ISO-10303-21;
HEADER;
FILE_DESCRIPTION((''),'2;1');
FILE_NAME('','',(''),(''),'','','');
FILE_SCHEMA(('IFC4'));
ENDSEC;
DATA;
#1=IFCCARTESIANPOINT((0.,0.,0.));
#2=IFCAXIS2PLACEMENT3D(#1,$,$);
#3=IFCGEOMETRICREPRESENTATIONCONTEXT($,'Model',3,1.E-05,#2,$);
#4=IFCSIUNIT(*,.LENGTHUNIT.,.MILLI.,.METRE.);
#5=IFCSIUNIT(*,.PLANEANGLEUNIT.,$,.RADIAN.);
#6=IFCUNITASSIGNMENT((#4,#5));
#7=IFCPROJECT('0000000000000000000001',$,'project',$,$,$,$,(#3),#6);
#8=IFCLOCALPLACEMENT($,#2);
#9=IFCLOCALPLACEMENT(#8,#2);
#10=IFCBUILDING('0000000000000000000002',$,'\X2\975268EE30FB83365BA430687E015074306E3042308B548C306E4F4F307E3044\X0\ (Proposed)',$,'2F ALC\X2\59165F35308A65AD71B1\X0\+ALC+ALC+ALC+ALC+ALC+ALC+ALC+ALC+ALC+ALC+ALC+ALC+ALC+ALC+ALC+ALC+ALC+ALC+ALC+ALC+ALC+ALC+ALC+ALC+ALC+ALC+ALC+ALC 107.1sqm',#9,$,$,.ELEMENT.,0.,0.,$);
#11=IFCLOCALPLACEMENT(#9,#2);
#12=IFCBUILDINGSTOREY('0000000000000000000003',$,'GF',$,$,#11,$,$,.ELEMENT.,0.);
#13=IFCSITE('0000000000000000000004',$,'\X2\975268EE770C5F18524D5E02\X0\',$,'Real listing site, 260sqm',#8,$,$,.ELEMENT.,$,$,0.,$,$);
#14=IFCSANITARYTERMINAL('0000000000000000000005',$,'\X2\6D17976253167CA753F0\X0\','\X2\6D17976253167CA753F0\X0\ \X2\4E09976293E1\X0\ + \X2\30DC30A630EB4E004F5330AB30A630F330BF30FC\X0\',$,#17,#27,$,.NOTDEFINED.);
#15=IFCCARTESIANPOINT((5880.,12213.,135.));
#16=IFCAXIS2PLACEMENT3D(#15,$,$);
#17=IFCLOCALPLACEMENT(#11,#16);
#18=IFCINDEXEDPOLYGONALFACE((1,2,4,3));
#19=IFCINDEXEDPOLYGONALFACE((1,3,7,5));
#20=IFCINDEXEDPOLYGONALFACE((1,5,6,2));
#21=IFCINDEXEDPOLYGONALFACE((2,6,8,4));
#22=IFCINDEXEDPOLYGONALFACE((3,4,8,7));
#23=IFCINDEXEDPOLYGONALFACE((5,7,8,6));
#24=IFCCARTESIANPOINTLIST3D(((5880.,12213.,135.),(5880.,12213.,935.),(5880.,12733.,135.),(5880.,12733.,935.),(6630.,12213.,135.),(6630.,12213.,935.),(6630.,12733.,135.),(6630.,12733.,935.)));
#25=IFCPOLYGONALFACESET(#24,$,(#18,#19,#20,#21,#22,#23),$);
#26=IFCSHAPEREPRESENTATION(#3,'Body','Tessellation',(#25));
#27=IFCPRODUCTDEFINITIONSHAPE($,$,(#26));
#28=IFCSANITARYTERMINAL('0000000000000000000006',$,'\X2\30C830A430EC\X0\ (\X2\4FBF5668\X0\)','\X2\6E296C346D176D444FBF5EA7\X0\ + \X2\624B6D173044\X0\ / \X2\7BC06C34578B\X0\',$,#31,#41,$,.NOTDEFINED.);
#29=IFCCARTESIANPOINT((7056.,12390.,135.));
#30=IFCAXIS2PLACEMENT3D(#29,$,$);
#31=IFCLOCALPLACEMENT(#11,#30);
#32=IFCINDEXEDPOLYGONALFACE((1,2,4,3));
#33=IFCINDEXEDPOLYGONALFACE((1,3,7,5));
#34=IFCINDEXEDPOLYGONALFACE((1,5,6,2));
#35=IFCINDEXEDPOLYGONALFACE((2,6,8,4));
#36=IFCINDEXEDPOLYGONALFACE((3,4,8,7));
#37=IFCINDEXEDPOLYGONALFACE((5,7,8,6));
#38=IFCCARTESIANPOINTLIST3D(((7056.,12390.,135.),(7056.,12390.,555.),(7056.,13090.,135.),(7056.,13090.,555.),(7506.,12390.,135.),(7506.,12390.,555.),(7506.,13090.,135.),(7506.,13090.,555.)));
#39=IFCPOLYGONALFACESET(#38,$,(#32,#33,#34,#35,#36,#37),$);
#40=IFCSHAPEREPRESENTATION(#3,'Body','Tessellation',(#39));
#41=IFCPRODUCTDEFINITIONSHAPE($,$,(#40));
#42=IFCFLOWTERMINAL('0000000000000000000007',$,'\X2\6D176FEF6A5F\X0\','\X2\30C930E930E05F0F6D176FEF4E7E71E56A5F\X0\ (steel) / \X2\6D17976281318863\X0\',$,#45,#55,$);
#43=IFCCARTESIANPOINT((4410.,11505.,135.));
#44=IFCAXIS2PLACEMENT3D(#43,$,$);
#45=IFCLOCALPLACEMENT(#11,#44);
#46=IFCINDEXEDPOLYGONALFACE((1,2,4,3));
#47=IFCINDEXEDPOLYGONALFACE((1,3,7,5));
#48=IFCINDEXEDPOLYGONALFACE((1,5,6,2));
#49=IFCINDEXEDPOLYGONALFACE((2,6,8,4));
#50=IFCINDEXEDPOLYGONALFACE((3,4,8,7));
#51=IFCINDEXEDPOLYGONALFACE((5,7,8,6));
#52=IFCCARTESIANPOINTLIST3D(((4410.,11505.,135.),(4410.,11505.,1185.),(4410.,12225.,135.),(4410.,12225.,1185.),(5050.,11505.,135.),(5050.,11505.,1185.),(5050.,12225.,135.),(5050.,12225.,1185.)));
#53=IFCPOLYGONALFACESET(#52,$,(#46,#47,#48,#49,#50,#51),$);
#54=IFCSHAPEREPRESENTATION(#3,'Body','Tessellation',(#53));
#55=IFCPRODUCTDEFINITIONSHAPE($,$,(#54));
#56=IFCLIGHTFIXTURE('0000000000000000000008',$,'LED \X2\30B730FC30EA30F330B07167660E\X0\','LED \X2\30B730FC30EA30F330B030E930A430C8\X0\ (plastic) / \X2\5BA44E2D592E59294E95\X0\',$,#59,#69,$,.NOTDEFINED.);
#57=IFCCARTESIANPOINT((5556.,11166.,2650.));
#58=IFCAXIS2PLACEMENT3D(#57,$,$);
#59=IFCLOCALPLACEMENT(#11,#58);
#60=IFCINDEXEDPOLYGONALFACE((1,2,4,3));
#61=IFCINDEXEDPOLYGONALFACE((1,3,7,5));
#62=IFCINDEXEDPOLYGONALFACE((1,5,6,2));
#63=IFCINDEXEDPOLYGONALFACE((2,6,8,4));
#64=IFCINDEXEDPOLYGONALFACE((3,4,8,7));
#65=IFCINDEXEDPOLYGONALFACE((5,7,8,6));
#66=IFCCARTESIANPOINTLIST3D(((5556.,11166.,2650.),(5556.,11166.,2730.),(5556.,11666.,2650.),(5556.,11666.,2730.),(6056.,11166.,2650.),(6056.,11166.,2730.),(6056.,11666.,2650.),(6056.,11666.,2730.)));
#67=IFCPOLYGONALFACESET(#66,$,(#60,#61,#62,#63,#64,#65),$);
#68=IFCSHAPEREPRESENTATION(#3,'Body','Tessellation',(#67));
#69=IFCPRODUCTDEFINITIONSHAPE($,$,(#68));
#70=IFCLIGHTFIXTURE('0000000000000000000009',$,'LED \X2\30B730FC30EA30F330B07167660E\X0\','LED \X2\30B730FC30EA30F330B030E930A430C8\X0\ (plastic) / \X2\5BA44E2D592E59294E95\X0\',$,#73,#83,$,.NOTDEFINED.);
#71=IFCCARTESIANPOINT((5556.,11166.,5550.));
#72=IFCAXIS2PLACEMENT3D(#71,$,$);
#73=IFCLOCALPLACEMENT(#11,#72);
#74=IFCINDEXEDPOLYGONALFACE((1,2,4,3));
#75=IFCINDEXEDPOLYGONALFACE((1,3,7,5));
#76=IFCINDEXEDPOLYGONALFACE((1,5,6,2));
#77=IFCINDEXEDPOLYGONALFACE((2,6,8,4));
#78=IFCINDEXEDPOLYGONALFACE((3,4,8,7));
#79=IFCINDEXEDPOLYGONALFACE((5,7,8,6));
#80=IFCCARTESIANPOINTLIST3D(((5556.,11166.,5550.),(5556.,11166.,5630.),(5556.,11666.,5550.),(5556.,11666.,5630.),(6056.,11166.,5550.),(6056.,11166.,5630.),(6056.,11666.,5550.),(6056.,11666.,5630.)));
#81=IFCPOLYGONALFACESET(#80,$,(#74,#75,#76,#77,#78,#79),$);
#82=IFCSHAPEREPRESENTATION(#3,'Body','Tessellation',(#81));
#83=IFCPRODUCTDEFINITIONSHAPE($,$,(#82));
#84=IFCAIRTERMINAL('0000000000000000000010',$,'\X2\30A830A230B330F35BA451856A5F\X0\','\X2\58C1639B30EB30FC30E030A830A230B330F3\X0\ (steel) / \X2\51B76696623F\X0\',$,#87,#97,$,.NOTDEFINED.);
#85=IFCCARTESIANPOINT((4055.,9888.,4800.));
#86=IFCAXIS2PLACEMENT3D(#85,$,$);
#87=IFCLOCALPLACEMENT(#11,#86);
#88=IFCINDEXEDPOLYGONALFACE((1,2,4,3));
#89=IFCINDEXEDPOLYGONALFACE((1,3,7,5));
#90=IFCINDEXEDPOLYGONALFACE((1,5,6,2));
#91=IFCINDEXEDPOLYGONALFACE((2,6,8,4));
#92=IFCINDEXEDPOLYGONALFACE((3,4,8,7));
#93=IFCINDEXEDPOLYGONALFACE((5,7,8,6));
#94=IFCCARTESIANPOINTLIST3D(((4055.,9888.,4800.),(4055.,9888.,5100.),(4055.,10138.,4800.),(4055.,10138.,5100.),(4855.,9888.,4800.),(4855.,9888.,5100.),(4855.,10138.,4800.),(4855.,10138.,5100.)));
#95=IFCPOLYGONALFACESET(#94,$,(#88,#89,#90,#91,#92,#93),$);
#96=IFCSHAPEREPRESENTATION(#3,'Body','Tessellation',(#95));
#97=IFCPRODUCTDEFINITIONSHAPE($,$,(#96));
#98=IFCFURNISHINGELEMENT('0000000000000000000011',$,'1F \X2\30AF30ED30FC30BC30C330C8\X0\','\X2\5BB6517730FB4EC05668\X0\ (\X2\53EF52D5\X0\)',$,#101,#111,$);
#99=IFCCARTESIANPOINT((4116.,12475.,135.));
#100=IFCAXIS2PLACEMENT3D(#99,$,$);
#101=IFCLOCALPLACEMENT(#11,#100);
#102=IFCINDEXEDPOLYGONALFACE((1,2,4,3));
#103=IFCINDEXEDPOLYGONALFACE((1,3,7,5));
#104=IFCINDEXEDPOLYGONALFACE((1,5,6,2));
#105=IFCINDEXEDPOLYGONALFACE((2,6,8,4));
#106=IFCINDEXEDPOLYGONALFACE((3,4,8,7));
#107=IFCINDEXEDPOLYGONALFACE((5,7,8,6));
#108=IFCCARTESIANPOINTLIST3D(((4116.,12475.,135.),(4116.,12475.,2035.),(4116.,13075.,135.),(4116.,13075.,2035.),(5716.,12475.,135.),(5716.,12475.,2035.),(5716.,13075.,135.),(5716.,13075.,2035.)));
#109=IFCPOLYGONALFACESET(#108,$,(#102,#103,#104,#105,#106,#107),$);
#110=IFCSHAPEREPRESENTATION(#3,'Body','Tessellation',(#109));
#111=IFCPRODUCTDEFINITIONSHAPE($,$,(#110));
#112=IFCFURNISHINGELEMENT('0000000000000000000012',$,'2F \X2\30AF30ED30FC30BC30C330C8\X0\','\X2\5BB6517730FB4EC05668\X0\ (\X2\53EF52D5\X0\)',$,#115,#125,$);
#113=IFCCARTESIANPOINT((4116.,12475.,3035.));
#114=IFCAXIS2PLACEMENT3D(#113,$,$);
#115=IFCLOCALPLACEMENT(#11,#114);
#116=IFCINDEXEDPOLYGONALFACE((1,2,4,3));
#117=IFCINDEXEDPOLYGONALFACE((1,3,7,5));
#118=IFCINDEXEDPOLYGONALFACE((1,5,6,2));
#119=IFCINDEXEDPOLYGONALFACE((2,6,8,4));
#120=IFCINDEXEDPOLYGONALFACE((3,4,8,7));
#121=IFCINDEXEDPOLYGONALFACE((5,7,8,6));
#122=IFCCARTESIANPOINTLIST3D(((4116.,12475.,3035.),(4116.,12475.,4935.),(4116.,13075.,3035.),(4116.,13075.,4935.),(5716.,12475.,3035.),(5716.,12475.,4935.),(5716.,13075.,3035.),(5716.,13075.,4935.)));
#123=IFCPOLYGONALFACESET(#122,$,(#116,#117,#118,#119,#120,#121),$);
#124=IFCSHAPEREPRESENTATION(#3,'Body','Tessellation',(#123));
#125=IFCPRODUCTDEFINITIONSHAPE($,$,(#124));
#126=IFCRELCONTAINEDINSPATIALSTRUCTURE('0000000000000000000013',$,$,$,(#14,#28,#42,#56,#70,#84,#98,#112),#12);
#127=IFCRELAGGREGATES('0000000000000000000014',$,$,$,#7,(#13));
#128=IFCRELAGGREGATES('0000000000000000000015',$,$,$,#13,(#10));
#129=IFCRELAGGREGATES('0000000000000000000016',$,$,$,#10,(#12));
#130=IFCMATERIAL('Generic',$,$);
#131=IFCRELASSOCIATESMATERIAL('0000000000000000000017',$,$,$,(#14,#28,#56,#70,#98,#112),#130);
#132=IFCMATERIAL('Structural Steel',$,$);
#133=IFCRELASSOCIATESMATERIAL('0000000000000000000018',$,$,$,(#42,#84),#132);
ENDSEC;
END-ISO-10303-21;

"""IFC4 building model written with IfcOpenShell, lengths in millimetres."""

from ifc_helpers import new_model, si_unit, frame, frame_2d, origin, place, context, project, spatial, rectangle, extrude, material, element, save


model = new_model("IFC4")

# Units and contexts
model_context = context("Model", 3, precision=1e-05, world=origin())
ifc_project = project(units=[si_unit("LENGTHUNIT", "METRE", prefix="MILLI"), si_unit("PLANEANGLEUNIT", "RADIAN")], contexts=[model_context])

# Site, building, storey
site_placement = place(None, origin())
site = spatial("IfcSite", under=ifc_project, at=site_placement, Name="青森県弘前市", ObjectType="Real listing site, 260sqm", CompositionType="ELEMENT", RefElevation=0.0)
building_placement = place(site_placement, origin())
building = spatial("IfcBuilding", under=site, at=building_placement, Name="青森・茶室と縁側のある和の住まい (Proposed)", ObjectType="2F ALC外張り断熱+ALC+ALC+ALC+ALC+ALC+ALC+ALC+ALC+ALC+ALC+ALC+ALC+ALC+ALC+ALC+ALC+ALC+ALC+ALC+ALC+ALC+ALC+ALC+ALC+ALC+ALC+ALC+ALC 107.1sqm", CompositionType="ELEMENT", ElevationOfRefHeight=0.0, ElevationOfTerrain=0.0)
storey_placement = place(building_placement, origin())
storey = spatial("IfcBuildingStorey", under=building, at=storey_placement, Name="GF", CompositionType="ELEMENT", Elevation=0.0)

# Sanitary terminals
ifc_material_1 = material(Name="Generic")
sanitary_terminal_1_placement = place(storey_placement, frame((5880.0, 12213.0, 135.0)))
element("IfcSanitaryTerminal", 1, at=sanitary_terminal_1_placement, inside=storey, material=ifc_material_1, Name="洗面化粧台", Description="洗面化粧台 三面鏡 + ボウル一体カウンター", PredefinedType="NOTDEFINED", context=model_context, shape_type="SweptSolid", body=[
    extrude(rectangle(XDim=750.0, YDim=520.0, at=frame_2d((375.0, 260.0))), frame((5880.0, 12213.0, 135.0)), (0.0, 0.0, 1.0), 800.0),
])
sanitary_terminal_2_placement = place(storey_placement, frame((7056.0, 12390.0, 135.0)))
element("IfcSanitaryTerminal", 2, at=sanitary_terminal_2_placement, inside=storey, material=ifc_material_1, Name="トイレ (便器)", Description="温水洗浄便座 + 手洗い / 節水型", PredefinedType="NOTDEFINED", context=model_context, shape_type="SweptSolid", body=[
    extrude(rectangle(XDim=450.0, YDim=700.0, at=frame_2d((225.0, 350.0))), frame((7056.0, 12390.0, 135.0)), (0.0, 0.0, 1.0), 420.0),
])

# Flow terminal
ifc_material_2 = material(Name="Structural Steel")
flow_terminal_placement = place(storey_placement, frame((4410.0, 11505.0, 135.0)))
element("IfcFlowTerminal", 3, at=flow_terminal_placement, inside=storey, material=ifc_material_2, Name="洗濯機", Description="ドラム式洗濯乾燥機 (steel) / 洗面脱衣", context=model_context, shape_type="SweptSolid", body=[
    extrude(rectangle(XDim=640.0, YDim=720.0, at=frame_2d((320.0, 360.0))), frame((4410.0, 11505.0, 135.0)), (0.0, 0.0, 1.0), 1050.0),
])

# Light fixtures
light_fixture_1_placement = place(storey_placement, frame((5556.0, 11166.0, 2650.0)))
element("IfcLightFixture", 4, at=light_fixture_1_placement, inside=storey, material=ifc_material_1, Name="LED シーリング照明", Description="LED シーリングライト (plastic) / 室中央天井", PredefinedType="NOTDEFINED", context=model_context, shape_type="SweptSolid", body=[
    extrude(rectangle(XDim=500.0, YDim=500.0, at=frame_2d((250.0, 250.0))), frame((5556.0, 11166.0, 2650.0)), (0.0, 0.0, 1.0), 80.0),
])
light_fixture_2_placement = place(storey_placement, frame((5556.0, 11166.0, 5550.0)))
element("IfcLightFixture", 5, at=light_fixture_2_placement, inside=storey, material=ifc_material_1, Name="LED シーリング照明", Description="LED シーリングライト (plastic) / 室中央天井", PredefinedType="NOTDEFINED", context=model_context, shape_type="SweptSolid", body=[
    extrude(rectangle(XDim=500.0, YDim=500.0, at=frame_2d((250.0, 250.0))), frame((5556.0, 11166.0, 5550.0)), (0.0, 0.0, 1.0), 80.0),
])

# Air terminal
air_terminal_placement = place(storey_placement, frame((4055.0, 9888.0, 4800.0)))
element("IfcAirTerminal", 6, at=air_terminal_placement, inside=storey, material=ifc_material_2, Name="エアコン室内機", Description="壁掛ルームエアコン (steel) / 冷暖房", PredefinedType="NOTDEFINED", context=model_context, shape_type="SweptSolid", body=[
    extrude(rectangle(XDim=800.0, YDim=250.0, at=frame_2d((400.0, 125.0))), frame((4055.0, 9888.0, 4800.0)), (0.0, 0.0, 1.0), 300.0),
])

# Furnishing elements
furnishing_1_placement = place(storey_placement, frame((4116.0, 12475.0, 135.0)))
element("IfcFurnishingElement", 7, at=furnishing_1_placement, inside=storey, material=ifc_material_1, Name="1F クローゼット", Description="家具・什器 (可動)", context=model_context, shape_type="SweptSolid", body=[
    extrude(rectangle(XDim=1600.0, YDim=600.0, at=frame_2d((800.0, 300.0))), frame((4116.0, 12475.0, 135.0)), (0.0, 0.0, 1.0), 1900.0),
])
furnishing_2_placement = place(storey_placement, frame((4116.0, 12475.0, 3035.0)))
element("IfcFurnishingElement", 8, at=furnishing_2_placement, inside=storey, material=ifc_material_1, Name="2F クローゼット", Description="家具・什器 (可動)", context=model_context, shape_type="SweptSolid", body=[
    extrude(rectangle(XDim=1600.0, YDim=600.0, at=frame_2d((800.0, 300.0))), frame((4116.0, 12475.0, 3035.0)), (0.0, 0.0, 1.0), 1900.0),
])

save(model, "model.ifc")
